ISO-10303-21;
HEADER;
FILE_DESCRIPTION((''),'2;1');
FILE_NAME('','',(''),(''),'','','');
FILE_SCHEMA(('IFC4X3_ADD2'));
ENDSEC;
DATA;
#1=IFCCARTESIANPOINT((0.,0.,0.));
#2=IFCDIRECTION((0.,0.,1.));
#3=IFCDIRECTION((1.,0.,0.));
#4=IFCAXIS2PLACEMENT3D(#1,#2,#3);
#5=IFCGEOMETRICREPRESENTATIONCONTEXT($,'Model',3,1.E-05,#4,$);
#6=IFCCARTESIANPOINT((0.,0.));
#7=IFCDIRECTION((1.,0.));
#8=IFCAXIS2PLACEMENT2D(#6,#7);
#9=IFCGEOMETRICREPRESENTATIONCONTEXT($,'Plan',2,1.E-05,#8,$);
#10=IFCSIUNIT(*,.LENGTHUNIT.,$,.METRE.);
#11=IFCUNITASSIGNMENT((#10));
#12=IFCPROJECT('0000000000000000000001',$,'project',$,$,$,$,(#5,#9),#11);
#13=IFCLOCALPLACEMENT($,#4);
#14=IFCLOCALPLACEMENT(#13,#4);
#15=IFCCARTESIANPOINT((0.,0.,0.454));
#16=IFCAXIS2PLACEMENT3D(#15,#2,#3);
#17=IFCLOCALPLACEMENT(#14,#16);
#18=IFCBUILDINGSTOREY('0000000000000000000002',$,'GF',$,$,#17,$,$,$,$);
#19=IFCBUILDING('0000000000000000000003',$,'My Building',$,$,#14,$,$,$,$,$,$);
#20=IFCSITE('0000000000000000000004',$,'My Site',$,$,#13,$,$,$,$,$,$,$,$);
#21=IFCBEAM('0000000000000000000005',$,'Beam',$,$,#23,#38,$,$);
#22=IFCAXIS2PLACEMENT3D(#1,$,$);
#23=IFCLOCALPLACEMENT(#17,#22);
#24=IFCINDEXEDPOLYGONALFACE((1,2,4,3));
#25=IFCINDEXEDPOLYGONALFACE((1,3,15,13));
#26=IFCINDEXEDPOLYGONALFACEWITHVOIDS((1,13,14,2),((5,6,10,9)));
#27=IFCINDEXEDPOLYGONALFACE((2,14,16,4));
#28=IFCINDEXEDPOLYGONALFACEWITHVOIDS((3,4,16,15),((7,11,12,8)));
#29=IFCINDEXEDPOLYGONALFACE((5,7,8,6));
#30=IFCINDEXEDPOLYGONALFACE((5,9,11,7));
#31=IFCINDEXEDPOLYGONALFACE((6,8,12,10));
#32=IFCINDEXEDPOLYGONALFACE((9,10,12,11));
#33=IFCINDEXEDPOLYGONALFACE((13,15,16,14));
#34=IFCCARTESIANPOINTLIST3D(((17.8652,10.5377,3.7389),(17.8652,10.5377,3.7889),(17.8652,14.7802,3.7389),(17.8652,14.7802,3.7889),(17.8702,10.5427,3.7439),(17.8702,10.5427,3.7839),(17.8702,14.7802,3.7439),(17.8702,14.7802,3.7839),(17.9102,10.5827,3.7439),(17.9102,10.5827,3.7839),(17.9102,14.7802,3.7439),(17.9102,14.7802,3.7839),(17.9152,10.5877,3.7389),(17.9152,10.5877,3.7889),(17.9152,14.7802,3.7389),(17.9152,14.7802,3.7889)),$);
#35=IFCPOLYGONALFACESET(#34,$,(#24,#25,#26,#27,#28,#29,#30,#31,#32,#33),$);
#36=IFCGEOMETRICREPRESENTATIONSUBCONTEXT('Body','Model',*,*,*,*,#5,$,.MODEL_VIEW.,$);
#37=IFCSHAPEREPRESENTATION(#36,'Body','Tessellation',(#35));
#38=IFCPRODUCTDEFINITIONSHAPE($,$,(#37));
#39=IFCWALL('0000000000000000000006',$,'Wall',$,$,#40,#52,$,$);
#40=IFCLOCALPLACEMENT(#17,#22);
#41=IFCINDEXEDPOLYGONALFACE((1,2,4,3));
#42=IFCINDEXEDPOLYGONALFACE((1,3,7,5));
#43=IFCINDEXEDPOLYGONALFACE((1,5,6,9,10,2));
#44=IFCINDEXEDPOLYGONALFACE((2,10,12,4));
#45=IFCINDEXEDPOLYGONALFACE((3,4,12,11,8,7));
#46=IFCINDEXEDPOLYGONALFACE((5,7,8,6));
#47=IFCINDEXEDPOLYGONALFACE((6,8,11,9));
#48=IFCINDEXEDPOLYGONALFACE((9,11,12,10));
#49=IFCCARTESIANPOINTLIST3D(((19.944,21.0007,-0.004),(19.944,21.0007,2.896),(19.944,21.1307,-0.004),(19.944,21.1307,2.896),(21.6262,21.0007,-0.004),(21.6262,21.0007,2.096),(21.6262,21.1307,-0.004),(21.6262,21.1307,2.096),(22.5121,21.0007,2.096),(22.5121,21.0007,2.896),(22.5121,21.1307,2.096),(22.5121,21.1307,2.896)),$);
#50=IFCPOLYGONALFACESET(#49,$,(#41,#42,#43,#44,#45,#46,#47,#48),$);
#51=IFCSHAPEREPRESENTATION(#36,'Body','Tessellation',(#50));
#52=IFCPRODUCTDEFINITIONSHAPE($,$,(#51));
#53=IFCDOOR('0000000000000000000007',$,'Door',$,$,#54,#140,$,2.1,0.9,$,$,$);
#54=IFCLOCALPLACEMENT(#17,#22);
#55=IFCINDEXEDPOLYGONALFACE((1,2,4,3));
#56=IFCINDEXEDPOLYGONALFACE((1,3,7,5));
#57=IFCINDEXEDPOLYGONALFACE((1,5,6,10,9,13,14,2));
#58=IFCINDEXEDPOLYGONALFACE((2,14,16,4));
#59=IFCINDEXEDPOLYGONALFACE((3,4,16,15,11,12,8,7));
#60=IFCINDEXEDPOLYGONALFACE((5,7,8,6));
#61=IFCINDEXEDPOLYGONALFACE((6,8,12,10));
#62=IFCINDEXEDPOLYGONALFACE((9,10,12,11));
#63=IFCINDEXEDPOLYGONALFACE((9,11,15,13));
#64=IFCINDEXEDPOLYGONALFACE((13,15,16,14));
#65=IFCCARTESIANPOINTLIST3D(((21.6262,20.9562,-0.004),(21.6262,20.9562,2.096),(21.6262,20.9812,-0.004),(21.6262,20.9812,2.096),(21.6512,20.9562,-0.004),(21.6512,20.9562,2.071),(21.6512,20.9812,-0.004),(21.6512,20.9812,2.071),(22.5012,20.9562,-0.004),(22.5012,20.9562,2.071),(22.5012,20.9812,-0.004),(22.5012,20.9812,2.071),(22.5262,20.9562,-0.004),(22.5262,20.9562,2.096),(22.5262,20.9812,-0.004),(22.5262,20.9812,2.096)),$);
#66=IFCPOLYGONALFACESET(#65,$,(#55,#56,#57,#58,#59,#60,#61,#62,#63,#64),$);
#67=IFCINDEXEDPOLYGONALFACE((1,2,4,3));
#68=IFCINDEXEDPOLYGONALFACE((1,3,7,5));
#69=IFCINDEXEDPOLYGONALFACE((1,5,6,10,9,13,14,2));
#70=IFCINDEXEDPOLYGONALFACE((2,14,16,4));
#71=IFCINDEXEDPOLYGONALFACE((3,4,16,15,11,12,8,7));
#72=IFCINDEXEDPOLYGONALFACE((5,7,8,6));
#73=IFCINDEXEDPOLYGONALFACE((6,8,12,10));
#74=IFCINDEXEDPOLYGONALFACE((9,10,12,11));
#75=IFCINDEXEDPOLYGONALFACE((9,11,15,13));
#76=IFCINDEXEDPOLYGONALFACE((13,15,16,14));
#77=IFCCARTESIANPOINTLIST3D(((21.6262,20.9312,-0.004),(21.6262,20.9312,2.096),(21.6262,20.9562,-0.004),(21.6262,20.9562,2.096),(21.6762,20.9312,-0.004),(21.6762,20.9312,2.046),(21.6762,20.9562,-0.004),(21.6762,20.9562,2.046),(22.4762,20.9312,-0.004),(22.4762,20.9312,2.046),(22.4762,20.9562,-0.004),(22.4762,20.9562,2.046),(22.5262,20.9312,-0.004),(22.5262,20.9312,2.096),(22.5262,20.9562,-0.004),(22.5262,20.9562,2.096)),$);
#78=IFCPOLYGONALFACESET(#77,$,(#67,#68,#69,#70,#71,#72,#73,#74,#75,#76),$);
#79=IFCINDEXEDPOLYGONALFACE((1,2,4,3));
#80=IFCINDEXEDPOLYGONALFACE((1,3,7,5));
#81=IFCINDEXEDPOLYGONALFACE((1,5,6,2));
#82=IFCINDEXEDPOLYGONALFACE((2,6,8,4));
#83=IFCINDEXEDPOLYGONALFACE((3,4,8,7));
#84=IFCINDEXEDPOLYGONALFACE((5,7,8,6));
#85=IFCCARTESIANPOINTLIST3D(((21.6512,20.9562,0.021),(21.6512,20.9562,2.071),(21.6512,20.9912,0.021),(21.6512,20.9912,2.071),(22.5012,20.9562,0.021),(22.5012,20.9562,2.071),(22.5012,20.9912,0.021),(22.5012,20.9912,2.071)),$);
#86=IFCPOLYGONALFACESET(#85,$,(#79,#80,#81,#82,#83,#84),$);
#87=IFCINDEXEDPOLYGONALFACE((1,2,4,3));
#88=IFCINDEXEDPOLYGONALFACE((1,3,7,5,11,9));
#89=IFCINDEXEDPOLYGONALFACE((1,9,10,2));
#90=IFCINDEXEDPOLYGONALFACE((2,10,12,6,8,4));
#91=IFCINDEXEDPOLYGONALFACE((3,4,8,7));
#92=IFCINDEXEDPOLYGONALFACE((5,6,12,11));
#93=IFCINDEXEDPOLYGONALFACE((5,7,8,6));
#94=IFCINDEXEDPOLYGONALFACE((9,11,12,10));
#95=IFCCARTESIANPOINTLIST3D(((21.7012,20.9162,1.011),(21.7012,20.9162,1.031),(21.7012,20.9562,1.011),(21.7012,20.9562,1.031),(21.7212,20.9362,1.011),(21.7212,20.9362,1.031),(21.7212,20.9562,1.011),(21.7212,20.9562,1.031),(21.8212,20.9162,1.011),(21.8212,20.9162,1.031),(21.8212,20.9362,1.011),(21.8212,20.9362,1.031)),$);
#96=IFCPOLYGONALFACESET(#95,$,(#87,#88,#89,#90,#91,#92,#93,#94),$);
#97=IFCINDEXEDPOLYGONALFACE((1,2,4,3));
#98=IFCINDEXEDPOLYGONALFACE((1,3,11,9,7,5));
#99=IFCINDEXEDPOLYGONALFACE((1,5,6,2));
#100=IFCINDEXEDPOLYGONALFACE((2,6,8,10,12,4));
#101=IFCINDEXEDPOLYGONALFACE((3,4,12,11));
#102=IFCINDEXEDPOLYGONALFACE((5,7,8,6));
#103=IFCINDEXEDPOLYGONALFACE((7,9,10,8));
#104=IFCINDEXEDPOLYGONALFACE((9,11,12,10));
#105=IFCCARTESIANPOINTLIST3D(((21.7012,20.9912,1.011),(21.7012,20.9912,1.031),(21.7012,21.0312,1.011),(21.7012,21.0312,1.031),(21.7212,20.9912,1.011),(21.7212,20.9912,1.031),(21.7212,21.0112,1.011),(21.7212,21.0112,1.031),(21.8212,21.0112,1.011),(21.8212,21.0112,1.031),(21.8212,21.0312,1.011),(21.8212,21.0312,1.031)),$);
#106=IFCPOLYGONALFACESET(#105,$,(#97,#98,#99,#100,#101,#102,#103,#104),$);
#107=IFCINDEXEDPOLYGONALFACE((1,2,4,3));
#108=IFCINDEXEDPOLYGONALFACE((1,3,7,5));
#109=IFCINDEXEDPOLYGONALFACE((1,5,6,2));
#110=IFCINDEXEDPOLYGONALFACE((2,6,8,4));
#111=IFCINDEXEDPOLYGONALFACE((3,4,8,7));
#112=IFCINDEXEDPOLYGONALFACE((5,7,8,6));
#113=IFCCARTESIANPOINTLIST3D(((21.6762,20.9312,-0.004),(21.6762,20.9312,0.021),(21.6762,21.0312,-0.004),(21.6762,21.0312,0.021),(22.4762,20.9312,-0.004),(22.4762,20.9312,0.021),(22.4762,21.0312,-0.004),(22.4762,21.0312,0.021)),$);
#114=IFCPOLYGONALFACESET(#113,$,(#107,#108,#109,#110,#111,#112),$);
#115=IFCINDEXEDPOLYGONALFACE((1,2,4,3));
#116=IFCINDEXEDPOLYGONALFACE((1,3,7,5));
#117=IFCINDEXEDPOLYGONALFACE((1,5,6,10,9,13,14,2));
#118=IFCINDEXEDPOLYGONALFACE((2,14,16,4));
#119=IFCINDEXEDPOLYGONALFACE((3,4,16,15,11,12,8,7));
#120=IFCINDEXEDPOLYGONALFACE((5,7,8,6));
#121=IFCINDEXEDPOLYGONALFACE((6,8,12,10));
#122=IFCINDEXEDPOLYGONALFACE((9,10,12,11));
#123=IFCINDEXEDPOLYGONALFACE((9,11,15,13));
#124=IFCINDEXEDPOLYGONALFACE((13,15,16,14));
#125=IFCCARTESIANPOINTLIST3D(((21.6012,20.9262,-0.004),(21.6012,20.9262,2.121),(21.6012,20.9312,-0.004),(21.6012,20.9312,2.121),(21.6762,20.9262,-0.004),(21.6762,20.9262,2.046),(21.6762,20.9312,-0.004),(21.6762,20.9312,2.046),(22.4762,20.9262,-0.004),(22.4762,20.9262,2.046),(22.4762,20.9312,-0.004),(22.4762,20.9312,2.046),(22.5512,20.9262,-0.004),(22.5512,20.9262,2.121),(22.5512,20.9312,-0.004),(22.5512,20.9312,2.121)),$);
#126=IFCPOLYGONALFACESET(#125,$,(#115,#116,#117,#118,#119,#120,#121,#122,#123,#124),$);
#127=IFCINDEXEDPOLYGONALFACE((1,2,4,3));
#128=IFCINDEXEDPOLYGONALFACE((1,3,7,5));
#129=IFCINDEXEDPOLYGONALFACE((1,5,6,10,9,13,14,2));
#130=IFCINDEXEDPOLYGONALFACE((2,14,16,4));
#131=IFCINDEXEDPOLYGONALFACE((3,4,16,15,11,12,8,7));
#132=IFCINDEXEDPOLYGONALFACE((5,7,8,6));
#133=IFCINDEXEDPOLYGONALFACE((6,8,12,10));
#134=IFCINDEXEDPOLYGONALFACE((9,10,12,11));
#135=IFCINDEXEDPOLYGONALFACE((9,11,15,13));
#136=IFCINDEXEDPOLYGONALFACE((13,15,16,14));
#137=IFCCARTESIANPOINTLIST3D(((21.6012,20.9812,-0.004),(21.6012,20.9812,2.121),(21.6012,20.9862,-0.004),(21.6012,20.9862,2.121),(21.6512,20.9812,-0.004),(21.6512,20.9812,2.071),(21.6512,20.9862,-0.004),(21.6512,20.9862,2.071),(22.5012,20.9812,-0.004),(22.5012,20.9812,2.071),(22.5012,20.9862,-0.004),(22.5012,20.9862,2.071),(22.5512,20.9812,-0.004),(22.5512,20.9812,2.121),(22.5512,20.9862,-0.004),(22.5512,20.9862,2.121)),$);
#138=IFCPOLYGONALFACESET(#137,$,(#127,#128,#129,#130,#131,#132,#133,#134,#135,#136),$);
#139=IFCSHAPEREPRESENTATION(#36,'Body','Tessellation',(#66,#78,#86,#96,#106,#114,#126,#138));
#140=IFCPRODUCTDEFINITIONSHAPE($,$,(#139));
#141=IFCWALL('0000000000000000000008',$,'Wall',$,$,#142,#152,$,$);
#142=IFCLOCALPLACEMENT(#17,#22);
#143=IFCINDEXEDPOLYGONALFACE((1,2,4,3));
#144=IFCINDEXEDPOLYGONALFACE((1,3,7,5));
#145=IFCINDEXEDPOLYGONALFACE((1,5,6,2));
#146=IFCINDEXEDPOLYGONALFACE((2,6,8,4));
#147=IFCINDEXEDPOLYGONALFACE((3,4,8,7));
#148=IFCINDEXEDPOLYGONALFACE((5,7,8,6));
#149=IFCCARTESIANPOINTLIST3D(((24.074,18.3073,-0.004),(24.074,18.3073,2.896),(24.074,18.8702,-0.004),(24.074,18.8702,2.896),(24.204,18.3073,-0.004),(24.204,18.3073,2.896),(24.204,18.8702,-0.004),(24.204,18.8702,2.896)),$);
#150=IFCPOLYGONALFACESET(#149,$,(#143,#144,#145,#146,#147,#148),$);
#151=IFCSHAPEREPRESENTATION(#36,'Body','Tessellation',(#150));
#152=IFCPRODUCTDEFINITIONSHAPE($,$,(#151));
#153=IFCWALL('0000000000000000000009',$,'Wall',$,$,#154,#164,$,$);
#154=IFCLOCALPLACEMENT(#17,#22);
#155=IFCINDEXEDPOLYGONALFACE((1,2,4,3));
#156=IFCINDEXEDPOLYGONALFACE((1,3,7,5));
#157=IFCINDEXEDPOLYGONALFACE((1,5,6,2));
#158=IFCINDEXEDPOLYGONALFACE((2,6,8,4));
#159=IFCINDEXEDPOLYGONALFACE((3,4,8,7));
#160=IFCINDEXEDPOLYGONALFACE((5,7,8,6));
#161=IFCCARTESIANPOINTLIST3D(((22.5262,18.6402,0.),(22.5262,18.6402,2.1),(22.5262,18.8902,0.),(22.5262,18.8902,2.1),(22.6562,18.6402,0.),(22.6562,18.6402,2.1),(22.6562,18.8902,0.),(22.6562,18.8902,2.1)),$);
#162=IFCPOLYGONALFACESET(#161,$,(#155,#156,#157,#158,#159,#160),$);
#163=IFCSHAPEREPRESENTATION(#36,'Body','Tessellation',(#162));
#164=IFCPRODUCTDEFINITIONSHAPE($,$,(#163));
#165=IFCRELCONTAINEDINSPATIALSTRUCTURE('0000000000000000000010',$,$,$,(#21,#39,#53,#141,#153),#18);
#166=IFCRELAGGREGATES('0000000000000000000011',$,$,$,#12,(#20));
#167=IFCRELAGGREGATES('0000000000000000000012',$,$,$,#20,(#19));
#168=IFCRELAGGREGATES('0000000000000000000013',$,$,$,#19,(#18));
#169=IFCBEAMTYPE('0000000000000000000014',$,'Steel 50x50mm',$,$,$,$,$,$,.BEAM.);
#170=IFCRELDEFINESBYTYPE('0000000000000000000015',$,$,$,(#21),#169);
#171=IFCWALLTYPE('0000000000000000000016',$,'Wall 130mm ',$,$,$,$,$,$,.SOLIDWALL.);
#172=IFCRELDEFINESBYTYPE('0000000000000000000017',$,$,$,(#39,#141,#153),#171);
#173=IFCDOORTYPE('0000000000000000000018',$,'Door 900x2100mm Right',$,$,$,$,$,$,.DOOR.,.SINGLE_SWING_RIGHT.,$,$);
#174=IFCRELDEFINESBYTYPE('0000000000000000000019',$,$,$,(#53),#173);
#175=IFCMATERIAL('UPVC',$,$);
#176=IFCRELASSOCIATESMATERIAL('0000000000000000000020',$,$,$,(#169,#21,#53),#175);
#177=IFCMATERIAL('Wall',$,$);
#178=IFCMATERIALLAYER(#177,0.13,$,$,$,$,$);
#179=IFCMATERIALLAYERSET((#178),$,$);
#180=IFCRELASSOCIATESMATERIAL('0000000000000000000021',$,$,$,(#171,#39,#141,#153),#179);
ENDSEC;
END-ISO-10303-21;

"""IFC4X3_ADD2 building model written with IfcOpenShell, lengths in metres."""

from ifc_helpers import new_model, entity, si_unit, frame, origin_with_axes, origin_2d_with_axis, place, context, subcontext, project, spatial, line, indexed_curve, hollow_rectangle, outline, extrude, clip, halfspace, shape, source, transform, mapped, material, layer, layer_set, layer_usage, material_profile, profile_set, profile_usage, type_object, type_shapes, element, fill, save


model = new_model("IFC4X3_ADD2")

# Units and contexts
model_context = context("Model", 3, precision=1e-05, world=origin_with_axes())
plan_context = context("Plan", 2, precision=1e-05, world=origin_2d_with_axis())
body_context_1 = subcontext(model_context, "Body", "Model", "MODEL_VIEW")
body_context_2 = subcontext(plan_context, "Body", "Plan", "PLAN_VIEW")
ifc_project = project(units=[si_unit("LENGTHUNIT", "METRE")], contexts=[model_context, plan_context])

# Site, building, storey
site_placement = place(None, origin_with_axes())
site = spatial("IfcSite", under=ifc_project, at=site_placement, Name="My Site")
building_placement = place(site_placement, origin_with_axes())
building = spatial("IfcBuilding", under=site, at=building_placement, Name="My Building")
storey_placement = place(building_placement, frame((0.0, 0.0, 0.454), z_axis=(0.0, 0.0, 1.0), x_axis=(1.0, 0.0, 0.0)))
storey = spatial("IfcBuildingStorey", under=building, at=storey_placement, Name="GF")

# Beam
ifc_material_1 = material(Name="UPVC")
ifc_material_profile = material_profile(ifc_material_1, hollow_rectangle(XDim=0.05, YDim=0.05, WallThickness=0.005))
ifc_profile_set = profile_set([ifc_material_profile])
ifc_profile_usage = profile_usage(ifc_profile_set)
beam_type = type_object("IfcBeamType", Name="Steel 50x50mm", PredefinedType="BEAM", material=ifc_profile_set)
beam_placement = place(storey_placement, frame((17.8902, 14.7802, 3.7639), z_axis=(0.0, -1.0, 0.0), x_axis=(1.0, 0.0, 0.0)))
element("IfcBeam", 1, at=beam_placement, inside=storey, type_object=beam_type, material=ifc_profile_usage, Name="Beam", context=body_context_1, shape_type="Clipping", body=[
    clip(extrude(hollow_rectangle(XDim=0.05, YDim=0.05, WallThickness=0.005), origin_with_axes(), (0.0, 0.0, 1.0), 4.2425), halfspace(frame((-0.025, -4.2179, 4.2425), z_axis=(0.707107, 0.0, 0.707107), x_axis=(0.0, -1.0, 0.0)), False)),
])

# Wall, opening, door
ifc_material_2 = material(Name="Wall")
ifc_layer_1 = layer(ifc_material_2, 0.13)
ifc_layer_set_1 = layer_set([ifc_layer_1])
ifc_layer_usage_1 = layer_usage(ifc_layer_set_1, "AXIS2", "POSITIVE", 0.0)
wall_type_1 = type_object("IfcWallType", Name="Wall 130mm ", PredefinedType="SOLIDWALL", material=ifc_layer_set_1)
wall_1_placement = place(storey_placement, frame((22.5121, 21.1307, -0.004), z_axis=(0.0, 0.0, 1.0), x_axis=(-1.0, 0.0, 0.0)))
wall_1 = element("IfcWall", 2, at=wall_1_placement, inside=storey, type_object=wall_type_1, material=ifc_layer_usage_1, Name="Wall", context=body_context_1, shape_type="SweptSolid", body=[
    extrude(outline(indexed_curve([(0.0, 0.0), (0.0, 0.13), (2.5681, 0.13), (2.5681, 0.0), (0.0, 0.0)], self_intersect=False)), origin_with_axes(), (0.0, 0.0, 1.0), 2.9),
])
shared_shape_1 = source(origin_with_axes(), body_context_1, "Body", "SweptSolid", [
    extrude(outline(indexed_curve([(0.0, 0.0), (0.9, 0.0), (0.9, 2.1), (0.0, 2.1)], segments=[line(1, 2, 3, 4, 1)])), frame((0.0, -0.6, 0.0), z_axis=(0.0, -1.0, 0.0), x_axis=(1.0, 0.0, 0.0)), (0.0, 0.0, -1.0), 1.2),
])
opening_1_placement = place(wall_1_placement, frame((0.8859, 0.1995, 0.0), z_axis=(0.0, 0.0, 1.0), x_axis=(-1.0, 0.0, 0.0)))
opening_1 = element("IfcOpeningElement", 3, at=opening_1_placement, cuts=wall_1, PredefinedType="OPENING", context=body_context_1, shape_type="MappedRepresentation", body=[
    mapped(shared_shape_1, transform((0.0, 0.0, 0.0), x_axis=(1.0, 0.0, 0.0), y_axis=(0.0, 1.0, 0.0), z_axis=(0.0, 0.0, 1.0), scale=1.0)),
])
door_type_1 = type_object("IfcDoorType", Name="Door 900x2100mm Right", OperationType="SINGLE_SWING_RIGHT", PredefinedType="DOOR")
shared_shape_2 = source(origin_with_axes(), body_context_1, "Body", "SweptSolid", [
    extrude(outline(indexed_curve([(0.0, 0.0), (0.0, 2.1), (0.9, 2.1), (0.9, 0.0), (0.875, 0.0), (0.875, 2.075), (0.025, 2.075), (0.025, 0.0)], segments=[line(1, 2, 3, 4, 5, 6, 7, 8, 1)])), frame((0.0, 0.025, 0.0), z_axis=(0.0, -1.0, 0.0), x_axis=(1.0, 0.0, 0.0)), (0.0, 0.0, -1.0), 0.025),
    extrude(outline(indexed_curve([(0.0, 0.0), (0.0, 2.1), (0.9, 2.1), (0.9, 0.0), (0.85, 0.0), (0.85, 2.05), (0.05, 2.05), (0.05, 0.0)], segments=[line(1, 2, 3, 4, 5, 6, 7, 8, 1)])), frame((0.0, 0.0, 0.0), z_axis=(0.0, -1.0, 0.0), x_axis=(1.0, 0.0, 0.0)), (0.0, 0.0, -1.0), 0.025),
    extrude(outline(indexed_curve([(0.0, 0.0), (0.85, 0.0), (0.85, 0.035), (0.0, 0.035)], segments=[line(1, 2, 3, 4, 1)])), frame((0.025, 0.025, 0.025), z_axis=(0.0, 0.0, 1.0), x_axis=(1.0, 0.0, 0.0)), (0.0, 0.0, 1.0), 2.05),
    extrude(outline(indexed_curve([(0.0, 0.0), (0.0, -0.04), (0.12, -0.04), (0.12, -0.02), (0.02, -0.02), (0.02, 0.0)], segments=[line(1, 2, 3, 4, 5, 6, 1)])), frame((0.075, 0.025, 1.015), z_axis=(0.0, 0.0, 1.0), x_axis=(1.0, 0.0, 0.0)), (0.0, 0.0, 1.0), 0.02),
    extrude(outline(indexed_curve([(0.0, 0.0), (0.0, 0.04), (0.12, 0.04), (0.12, 0.02), (0.02, 0.02), (0.02, 0.0)], segments=[line(1, 2, 3, 4, 5, 6, 1)])), frame((0.075, 0.06, 1.015), z_axis=(0.0, 0.0, 1.0), x_axis=(1.0, 0.0, 0.0)), (0.0, 0.0, 1.0), 0.02),
    extrude(outline(indexed_curve([(0.0, 0.0), (0.8, 0.0), (0.8, 0.1), (0.0, 0.1)], segments=[line(1, 2, 3, 4, 1)])), frame((0.05, 0.0, 0.0), z_axis=(0.0, 0.0, 1.0), x_axis=(1.0, 0.0, 0.0)), (0.0, 0.0, 1.0), 0.025),
    extrude(outline(indexed_curve([(0.0, 0.0), (0.0, 2.125), (0.95, 2.125), (0.95, 0.0), (0.875, 0.0), (0.875, 2.05), (0.075, 2.05), (0.075, 0.0)], segments=[line(1, 2, 3, 4, 5, 6, 7, 8, 1)])), frame((-0.025, -0.005, 0.0), z_axis=(0.0, -1.0, 0.0), x_axis=(1.0, 0.0, 0.0)), (0.0, 0.0, -1.0), 0.005),
    extrude(outline(indexed_curve([(0.0, 0.0), (0.0, 2.125), (0.95, 2.125), (0.95, 0.0), (0.9, 0.0), (0.9, 2.075), (0.05, 2.075), (0.05, 0.0)], segments=[line(1, 2, 3, 4, 5, 6, 7, 8, 1)])), frame((-0.025, 0.05, 0.0), z_axis=(0.0, -1.0, 0.0), x_axis=(1.0, 0.0, 0.0)), (0.0, 0.0, -1.0), 0.005),
])
shared_shape_3 = source(origin_with_axes(), body_context_2, "Body", "Curve2D", [
    entity("IfcIndexedPolyCurve", entity("IfcCartesianPointList2D", [[0.0, 0.0], [0.0, 0.05], [0.025, 0.05], [0.025, 0.025], [0.05, 0.025], [0.05, 0.0]]), [entity("IfcLineIndex", [1, 2, 3, 4, 5, 6, 1])]),
    entity("IfcIndexedPolyCurve", entity("IfcCartesianPointList2D", [[0.9, 0.0], [0.9, 0.05], [0.875, 0.05], [0.875, 0.025], [0.85, 0.025], [0.85, 0.0]]), [entity("IfcLineIndex", [1, 2, 3, 4, 5, 6, 1])]),
    entity("IfcTrimmedCurve", entity("IfcEllipse", entity("IfcAxis2Placement2D", entity("IfcCartesianPoint", [0.84, 0.05]), entity("IfcDirection", [1.0, 0.0])), 0.815, 0.85), [entity("IfcCartesianPoint", [0.84, 0.9])], [entity("IfcCartesianPoint", [0.025, 0.05])], True, "CARTESIAN"),
    entity("IfcIndexedPolyCurve", entity("IfcCartesianPointList2D", [[0.875, 0.05], [0.84, 0.05], [0.84, 0.9], [0.875, 0.9]]), [entity("IfcLineIndex", [1, 2, 3, 4, 1])]),
])
type_shapes(door_type_1, [shared_shape_2, shared_shape_3])
door_1_placement = place(opening_1_placement, frame((0.0, 0.0, 0.0), z_axis=(0.0, 0.0, 1.0), x_axis=(1.0, 0.0, 0.0)))
door_1 = element("IfcDoor", 4, at=door_1_placement, inside=storey, type_object=door_type_1, material=ifc_material_1, Name="Door", OverallHeight=2.1, OverallWidth=0.9, shapes=[
    shape(body_context_1, "Body", "MappedRepresentation", [mapped(shared_shape_2, transform((0.0, 0.0, 0.0), x_axis=(1.0, 0.0, 0.0), y_axis=(0.0, 1.0, 0.0), z_axis=(0.0, 0.0, 1.0), scale=1.0))]),
    shape(body_context_2, "Body", "MappedRepresentation", [mapped(shared_shape_3, transform((0.0, 0.0, 0.0), x_axis=(1.0, 0.0, 0.0), y_axis=(0.0, 1.0, 0.0), z_axis=(0.0, 0.0, 1.0), scale=1.0))]),
])
fill(opening_1, door_1)

# Walls
ifc_layer_usage_2 = layer_usage(ifc_layer_set_1, "AXIS2", "POSITIVE", 0.0)
wall_2_placement = place(storey_placement, frame((24.204, 18.3073, -0.004), z_axis=(0.0, 0.0, 1.0), x_axis=(0.000001, 1.0, 0.0)))
element("IfcWall", 5, at=wall_2_placement, inside=storey, type_object=wall_type_1, material=ifc_layer_usage_2, Name="Wall", context=body_context_1, shape_type="SweptSolid", body=[
    extrude(outline(indexed_curve([(0.0, 0.0), (0.0, 0.13), (0.5629, 0.13), (0.5629, 0.0), (0.0, 0.0)], self_intersect=False)), origin_with_axes(), (0.0, 0.0, 1.0), 2.9),
])
ifc_layer_usage_3 = layer_usage(ifc_layer_set_1, "AXIS2", "POSITIVE", 0.0)
wall_3_placement = place(storey_placement, frame((22.6562, 18.6402, 0.0), z_axis=(0.0, 0.0, 1.0), x_axis=(0.000002, 1.0, 0.0)))
element("IfcWall", 6, at=wall_3_placement, inside=storey, type_object=wall_type_1, material=ifc_layer_usage_3, Name="Wall", context=body_context_1, shape_type="Clipping", body=[
    clip(extrude(outline(indexed_curve([(0.0, 0.0), (0.0, 0.13), (0.25, 0.13), (0.25, 0.0), (0.0, 0.0)], self_intersect=False)), origin_with_axes(), (0.0, 0.0, 1.0), 2.554), halfspace(frame((0.0, 0.0, 2.1), z_axis=(0.0, 0.0, 1.0), x_axis=(-1.0, 0.0, 0.0)), False)),
])

save(model, "model.ifc")
